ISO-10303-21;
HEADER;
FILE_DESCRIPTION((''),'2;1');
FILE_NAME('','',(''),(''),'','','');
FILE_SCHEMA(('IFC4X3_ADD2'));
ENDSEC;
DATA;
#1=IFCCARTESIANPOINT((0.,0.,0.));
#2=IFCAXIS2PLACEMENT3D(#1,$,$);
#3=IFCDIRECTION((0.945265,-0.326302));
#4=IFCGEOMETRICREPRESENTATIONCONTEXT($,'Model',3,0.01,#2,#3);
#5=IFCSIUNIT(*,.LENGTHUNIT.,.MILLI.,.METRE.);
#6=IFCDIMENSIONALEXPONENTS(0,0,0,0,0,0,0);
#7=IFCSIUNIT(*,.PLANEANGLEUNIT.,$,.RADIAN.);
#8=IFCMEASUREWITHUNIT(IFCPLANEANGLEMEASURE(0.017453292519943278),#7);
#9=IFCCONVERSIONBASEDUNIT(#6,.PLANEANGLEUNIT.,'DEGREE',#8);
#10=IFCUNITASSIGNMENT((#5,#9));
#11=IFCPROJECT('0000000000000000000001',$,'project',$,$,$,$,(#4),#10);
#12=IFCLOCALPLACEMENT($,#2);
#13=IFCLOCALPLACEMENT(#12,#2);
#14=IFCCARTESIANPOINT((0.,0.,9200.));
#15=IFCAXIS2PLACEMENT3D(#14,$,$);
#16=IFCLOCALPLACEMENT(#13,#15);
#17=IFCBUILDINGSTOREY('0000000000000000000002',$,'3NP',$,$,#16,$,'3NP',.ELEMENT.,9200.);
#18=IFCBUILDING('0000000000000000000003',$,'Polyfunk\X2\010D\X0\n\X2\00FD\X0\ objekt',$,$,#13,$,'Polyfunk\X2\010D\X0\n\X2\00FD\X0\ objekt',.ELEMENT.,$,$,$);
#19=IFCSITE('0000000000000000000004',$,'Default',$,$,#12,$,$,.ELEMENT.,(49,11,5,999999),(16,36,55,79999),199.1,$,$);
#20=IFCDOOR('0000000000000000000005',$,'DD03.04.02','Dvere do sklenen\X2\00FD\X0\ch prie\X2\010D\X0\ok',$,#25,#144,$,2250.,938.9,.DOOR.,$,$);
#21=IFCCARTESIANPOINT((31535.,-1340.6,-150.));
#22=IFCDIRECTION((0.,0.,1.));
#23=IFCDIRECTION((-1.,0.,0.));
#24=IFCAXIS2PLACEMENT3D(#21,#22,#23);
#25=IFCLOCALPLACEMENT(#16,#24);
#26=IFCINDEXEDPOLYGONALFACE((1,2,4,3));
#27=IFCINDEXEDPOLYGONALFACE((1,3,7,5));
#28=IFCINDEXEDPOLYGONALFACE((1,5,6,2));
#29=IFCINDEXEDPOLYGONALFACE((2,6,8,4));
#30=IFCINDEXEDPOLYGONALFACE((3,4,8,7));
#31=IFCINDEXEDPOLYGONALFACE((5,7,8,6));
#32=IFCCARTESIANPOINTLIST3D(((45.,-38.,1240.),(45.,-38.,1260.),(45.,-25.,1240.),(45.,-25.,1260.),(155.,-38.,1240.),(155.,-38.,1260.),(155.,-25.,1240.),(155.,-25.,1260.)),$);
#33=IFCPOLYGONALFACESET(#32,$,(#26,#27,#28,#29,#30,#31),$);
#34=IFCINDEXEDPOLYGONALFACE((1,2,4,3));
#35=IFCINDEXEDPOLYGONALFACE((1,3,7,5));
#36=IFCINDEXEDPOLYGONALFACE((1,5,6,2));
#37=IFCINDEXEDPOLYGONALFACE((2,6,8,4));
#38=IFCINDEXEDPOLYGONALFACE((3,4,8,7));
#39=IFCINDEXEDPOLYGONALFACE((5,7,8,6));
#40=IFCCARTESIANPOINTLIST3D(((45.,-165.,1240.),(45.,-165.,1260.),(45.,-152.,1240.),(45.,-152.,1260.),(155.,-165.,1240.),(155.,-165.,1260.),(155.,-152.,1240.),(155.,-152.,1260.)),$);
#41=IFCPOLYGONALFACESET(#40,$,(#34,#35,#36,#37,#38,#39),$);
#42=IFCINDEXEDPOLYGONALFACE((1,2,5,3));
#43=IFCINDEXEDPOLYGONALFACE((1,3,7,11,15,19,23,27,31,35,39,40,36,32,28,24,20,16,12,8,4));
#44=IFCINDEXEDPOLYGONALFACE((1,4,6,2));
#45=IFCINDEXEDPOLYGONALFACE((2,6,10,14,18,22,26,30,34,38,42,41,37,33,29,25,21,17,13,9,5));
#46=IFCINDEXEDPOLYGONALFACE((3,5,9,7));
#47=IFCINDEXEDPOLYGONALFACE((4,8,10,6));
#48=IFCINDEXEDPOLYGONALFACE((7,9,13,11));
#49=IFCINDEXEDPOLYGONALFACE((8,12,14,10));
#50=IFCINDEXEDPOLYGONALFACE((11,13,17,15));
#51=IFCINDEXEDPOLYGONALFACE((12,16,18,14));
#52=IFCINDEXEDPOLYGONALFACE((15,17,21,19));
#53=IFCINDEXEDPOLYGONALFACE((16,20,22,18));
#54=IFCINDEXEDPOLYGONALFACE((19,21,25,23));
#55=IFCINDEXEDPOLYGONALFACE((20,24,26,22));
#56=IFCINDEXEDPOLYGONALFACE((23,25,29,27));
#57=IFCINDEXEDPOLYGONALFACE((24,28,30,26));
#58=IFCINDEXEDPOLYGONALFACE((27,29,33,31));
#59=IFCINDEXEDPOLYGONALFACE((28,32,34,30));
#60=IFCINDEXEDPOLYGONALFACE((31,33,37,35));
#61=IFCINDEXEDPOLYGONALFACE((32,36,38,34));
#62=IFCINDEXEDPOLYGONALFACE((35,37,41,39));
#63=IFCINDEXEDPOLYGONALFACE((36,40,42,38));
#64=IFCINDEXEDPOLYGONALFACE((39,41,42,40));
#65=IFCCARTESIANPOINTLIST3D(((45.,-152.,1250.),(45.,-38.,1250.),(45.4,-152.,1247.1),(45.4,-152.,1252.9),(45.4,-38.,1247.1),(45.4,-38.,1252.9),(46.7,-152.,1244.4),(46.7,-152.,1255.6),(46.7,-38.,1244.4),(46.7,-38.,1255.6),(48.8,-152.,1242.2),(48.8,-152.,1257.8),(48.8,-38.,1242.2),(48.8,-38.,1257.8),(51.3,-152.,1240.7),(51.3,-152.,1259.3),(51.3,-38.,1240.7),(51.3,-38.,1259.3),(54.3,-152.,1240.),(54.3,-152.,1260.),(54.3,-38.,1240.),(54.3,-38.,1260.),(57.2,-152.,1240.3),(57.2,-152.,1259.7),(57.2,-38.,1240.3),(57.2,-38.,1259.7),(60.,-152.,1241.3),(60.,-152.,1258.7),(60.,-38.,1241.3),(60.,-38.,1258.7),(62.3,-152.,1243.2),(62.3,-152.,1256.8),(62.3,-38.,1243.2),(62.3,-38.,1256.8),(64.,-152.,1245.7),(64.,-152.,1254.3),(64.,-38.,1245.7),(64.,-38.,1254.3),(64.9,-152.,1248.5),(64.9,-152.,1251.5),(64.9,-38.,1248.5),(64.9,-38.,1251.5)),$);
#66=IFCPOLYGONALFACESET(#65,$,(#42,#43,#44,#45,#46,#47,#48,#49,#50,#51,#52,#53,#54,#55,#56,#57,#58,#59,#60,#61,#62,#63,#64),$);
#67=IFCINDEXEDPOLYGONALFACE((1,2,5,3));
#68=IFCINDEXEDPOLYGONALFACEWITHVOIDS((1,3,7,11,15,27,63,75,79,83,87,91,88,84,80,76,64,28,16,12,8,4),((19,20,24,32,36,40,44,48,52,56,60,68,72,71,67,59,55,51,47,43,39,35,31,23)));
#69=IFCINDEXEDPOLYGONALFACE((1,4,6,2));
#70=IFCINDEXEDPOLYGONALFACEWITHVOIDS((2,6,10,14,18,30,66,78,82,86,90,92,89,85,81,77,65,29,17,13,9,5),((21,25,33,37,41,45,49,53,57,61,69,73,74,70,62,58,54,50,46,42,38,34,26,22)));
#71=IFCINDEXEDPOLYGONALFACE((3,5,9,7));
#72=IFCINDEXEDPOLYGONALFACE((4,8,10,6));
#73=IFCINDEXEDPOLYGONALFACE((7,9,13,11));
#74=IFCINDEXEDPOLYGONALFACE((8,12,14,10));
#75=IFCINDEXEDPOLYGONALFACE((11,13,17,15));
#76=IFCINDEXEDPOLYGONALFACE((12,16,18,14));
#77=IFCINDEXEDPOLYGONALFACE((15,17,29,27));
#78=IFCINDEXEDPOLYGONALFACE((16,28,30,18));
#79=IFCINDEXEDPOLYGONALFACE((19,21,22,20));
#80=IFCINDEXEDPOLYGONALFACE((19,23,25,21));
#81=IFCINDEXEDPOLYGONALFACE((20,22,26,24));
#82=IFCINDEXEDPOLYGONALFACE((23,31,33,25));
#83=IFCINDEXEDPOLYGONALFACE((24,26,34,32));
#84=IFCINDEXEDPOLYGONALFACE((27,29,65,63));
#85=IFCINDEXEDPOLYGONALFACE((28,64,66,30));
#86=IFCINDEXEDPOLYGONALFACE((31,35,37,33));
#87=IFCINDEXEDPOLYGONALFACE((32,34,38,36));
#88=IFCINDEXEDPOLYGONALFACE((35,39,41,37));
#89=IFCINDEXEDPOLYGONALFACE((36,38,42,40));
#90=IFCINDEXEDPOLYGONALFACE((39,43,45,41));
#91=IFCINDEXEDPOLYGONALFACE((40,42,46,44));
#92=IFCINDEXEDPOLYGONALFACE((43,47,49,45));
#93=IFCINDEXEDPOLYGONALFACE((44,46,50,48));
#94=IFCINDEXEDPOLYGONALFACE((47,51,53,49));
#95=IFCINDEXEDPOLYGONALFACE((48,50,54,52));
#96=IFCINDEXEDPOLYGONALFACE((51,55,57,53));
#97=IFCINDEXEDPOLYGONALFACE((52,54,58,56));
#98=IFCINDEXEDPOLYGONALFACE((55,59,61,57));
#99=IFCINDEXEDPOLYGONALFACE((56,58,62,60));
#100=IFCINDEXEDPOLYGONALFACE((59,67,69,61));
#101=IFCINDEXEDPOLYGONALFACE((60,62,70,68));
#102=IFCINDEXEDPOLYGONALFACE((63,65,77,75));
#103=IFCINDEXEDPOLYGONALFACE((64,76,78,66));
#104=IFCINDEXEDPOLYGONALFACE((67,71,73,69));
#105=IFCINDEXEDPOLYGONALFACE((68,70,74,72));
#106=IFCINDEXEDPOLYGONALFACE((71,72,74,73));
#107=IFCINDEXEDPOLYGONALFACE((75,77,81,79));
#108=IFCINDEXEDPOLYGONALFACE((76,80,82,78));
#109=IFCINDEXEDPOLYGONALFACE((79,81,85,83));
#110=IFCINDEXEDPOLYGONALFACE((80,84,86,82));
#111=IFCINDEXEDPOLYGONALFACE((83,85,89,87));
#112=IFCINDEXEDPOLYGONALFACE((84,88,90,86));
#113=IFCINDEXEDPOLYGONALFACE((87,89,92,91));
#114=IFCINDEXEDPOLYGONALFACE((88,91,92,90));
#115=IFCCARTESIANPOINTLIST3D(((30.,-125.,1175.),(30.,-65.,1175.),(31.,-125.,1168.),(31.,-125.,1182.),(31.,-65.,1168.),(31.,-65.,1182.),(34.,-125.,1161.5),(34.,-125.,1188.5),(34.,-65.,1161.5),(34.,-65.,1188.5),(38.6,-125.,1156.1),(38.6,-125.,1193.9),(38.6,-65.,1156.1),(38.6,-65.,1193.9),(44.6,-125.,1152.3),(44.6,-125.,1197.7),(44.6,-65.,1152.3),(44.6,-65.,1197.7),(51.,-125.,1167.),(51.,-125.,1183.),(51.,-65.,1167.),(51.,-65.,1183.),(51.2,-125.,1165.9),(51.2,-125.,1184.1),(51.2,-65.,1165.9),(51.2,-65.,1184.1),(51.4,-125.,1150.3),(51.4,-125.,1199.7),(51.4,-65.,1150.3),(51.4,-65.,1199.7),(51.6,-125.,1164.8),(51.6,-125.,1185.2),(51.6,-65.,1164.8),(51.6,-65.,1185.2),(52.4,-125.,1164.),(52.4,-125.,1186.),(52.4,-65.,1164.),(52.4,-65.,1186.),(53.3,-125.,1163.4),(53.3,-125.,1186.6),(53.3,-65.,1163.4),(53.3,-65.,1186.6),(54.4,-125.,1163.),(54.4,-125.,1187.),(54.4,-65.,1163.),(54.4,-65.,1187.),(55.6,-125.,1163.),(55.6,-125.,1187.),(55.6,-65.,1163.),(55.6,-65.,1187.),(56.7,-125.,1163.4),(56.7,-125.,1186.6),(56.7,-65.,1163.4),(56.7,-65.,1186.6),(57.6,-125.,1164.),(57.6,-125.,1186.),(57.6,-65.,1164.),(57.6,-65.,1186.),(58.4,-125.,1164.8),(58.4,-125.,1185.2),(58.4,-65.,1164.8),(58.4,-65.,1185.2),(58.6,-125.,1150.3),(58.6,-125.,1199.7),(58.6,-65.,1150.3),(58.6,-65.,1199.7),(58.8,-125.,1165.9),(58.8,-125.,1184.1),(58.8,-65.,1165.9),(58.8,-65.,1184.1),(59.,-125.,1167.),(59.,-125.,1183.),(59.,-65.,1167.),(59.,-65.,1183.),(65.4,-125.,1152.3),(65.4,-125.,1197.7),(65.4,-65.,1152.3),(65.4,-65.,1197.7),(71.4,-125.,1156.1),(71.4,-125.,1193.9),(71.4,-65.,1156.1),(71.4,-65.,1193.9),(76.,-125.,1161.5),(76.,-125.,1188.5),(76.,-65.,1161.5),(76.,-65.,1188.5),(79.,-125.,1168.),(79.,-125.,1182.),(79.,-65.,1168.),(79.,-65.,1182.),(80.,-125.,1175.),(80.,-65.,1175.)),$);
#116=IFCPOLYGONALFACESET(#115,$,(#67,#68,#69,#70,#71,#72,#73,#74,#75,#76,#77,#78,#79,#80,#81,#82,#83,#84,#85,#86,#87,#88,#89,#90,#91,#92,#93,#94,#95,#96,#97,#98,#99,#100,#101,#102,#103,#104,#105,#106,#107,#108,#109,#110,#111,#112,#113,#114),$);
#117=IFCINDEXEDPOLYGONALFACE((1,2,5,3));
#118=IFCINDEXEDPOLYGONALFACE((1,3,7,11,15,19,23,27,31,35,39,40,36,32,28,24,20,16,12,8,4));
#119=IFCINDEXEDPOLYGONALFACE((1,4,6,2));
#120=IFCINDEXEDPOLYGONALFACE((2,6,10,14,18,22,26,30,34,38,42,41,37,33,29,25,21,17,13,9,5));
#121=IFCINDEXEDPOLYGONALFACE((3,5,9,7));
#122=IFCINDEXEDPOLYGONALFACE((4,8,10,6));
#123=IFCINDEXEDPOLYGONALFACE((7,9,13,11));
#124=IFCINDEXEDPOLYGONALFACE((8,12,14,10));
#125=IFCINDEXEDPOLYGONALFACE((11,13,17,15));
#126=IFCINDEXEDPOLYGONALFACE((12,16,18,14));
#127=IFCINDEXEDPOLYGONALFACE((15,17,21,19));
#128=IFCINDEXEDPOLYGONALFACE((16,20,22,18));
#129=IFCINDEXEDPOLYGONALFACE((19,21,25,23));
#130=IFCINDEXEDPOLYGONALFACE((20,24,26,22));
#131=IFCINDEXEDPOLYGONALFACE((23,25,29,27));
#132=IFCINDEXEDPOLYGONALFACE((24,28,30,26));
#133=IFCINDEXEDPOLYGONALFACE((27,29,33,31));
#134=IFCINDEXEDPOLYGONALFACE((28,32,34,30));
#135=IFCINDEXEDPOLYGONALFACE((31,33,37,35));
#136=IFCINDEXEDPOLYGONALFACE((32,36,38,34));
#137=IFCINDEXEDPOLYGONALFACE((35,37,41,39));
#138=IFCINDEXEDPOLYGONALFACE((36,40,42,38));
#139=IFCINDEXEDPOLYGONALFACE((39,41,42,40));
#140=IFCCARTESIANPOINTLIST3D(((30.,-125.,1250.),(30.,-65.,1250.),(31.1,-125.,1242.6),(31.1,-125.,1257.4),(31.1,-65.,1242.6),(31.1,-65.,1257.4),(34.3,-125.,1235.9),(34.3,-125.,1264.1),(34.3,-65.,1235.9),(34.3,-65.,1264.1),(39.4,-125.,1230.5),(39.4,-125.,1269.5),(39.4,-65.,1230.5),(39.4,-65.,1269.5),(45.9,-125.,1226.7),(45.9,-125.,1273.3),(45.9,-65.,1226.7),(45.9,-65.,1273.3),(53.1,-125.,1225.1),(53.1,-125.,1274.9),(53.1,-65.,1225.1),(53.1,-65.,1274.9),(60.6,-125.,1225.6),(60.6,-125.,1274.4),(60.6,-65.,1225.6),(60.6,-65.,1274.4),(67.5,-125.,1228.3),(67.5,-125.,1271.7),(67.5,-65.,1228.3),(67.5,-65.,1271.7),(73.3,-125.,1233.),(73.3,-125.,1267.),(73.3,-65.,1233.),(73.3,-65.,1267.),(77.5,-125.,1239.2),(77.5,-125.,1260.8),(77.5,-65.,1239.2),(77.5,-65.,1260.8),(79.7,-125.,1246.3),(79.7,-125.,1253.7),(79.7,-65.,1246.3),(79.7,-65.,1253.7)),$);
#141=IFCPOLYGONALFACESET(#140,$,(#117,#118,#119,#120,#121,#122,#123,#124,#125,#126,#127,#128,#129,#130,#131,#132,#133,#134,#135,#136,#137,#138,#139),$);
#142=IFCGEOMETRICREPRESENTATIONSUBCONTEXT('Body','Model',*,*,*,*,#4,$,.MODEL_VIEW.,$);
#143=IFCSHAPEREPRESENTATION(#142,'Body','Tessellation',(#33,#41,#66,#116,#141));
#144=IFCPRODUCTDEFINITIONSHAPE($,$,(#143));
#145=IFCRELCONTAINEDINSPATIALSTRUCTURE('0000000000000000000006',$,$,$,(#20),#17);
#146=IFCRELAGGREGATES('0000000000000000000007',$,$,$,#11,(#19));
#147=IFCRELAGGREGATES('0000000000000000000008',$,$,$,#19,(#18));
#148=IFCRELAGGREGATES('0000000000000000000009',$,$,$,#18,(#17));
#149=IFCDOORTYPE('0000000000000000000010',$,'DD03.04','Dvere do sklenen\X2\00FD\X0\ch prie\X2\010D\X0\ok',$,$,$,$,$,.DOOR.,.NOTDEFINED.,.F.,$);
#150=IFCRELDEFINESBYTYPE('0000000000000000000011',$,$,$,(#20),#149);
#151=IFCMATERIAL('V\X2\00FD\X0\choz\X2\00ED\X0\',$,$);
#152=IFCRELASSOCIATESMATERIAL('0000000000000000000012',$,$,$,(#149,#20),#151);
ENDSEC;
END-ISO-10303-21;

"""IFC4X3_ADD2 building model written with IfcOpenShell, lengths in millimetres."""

from ifc_helpers import new_model, entity, si_unit, converted_unit, direction, frame, frame_2d, origin, origin_2d_with_axis, place, context, subcontext, project, spatial, polyline, circle_curve, parameter, trimmed, segment, composite_curve, rectangle, circle, outline, extrude, source, transform, mapped, material, type_object, type_shapes, element, save


model = new_model("IFC4X3_ADD2")

# Units and contexts
model_context = context("Model", 3, precision=0.01, world=origin(), true_north=direction((0.945265, -0.326302)))
body_context = subcontext(model_context, "Body", "Model", "MODEL_VIEW")
ifc_project = project(units=[si_unit("LENGTHUNIT", "METRE", prefix="MILLI"), converted_unit("PLANEANGLEUNIT", "DEGREE", entity("IfcPlaneAngleMeasure", 0.017453292519943278), si_unit("PLANEANGLEUNIT", "RADIAN"), dimensions=[0, 0, 0, 0, 0, 0, 0])], contexts=[model_context])

# Site, building, storey
site_placement = place(None, origin())
site = spatial("IfcSite", under=ifc_project, at=site_placement, Name="Default", CompositionType="ELEMENT", RefLatitude=(49, 11, 5, 999999), RefLongitude=(16, 36, 55, 79999), RefElevation=199.1)
building_placement = place(site_placement, origin())
building = spatial("IfcBuilding", under=site, at=building_placement, Name="Polyfunkčný objekt", LongName="Polyfunkčný objekt", CompositionType="ELEMENT")
storey_placement = place(building_placement, frame((0.0, 0.0, 9200.0)))
storey = spatial("IfcBuildingStorey", under=building, at=storey_placement, Name="3NP", LongName="3NP", CompositionType="ELEMENT", Elevation=9200.0)

# Door
ifc_material_1 = material(Name="Výchozí")
door_type = type_object("IfcDoorType", Name="DD03.04", Description="Dvere do sklenených priečok", OperationType="NOTDEFINED", ParameterTakesPrecedence=False, PredefinedType="DOOR", material=ifc_material_1)
shared_shape_1 = source(origin(), body_context, "Body", "SweptSolid", [
    extrude(rectangle(XDim=110.0, YDim=13.0, at=frame_2d((0.0, 0.0), x_axis=(1.0, 0.0))), frame((100.0, -31.5, 1240.0)), (0.0, 0.0, 1.0), 20.0),
    extrude(rectangle(XDim=110.0, YDim=13.0, at=origin_2d_with_axis()), frame((100.0, -158.5, 1240.0), z_axis=(0.0, 0.0, 1.0), x_axis=(-1.0, 0.0, 0.0)), (0.0, 0.0, 1.0), 20.0),
    extrude(circle(Radius=10.0, at=origin_2d_with_axis()), frame((55.0, -152.0, 1250.0), z_axis=(0.0, 1.0, 0.0), x_axis=(-1.0, 0.0, 0.0)), (0.0, 0.0, 1.0), 114.0),
    extrude(outline(composite_curve([segment(trimmed(circle_curve(origin_2d_with_axis(), 25.0), [parameter(180.0)], [parameter(360.0)], True, "PARAMETER"), True, "CONTINUOUS"), segment(trimmed(circle_curve(origin_2d_with_axis(), 25.0), [parameter(0.0)], [parameter(180.0)], True, "PARAMETER"), True, "CONTINUOUS")], self_intersect=False), holes=[composite_curve([segment(trimmed(circle_curve(frame_2d((0.0, 8.0), x_axis=(1.0, 0.0)), 4.0), [parameter(0.0)], [parameter(180.0)], True, "PARAMETER"), False, "CONTINUOUS"), segment(polyline([(4.0, 8.0), (4.0, -8.0)]), True, "CONTINUOUS"), segment(trimmed(circle_curve(frame_2d((0.0, -8.0), x_axis=(1.0, 0.0)), 4.0), [parameter(180.0)], [parameter(0.0)], True, "PARAMETER"), False, "CONTINUOUS"), segment(polyline([(-4.0, -8.0), (-4.0, 8.0)]), True, "CONTINUOUS")], self_intersect=False)]), frame((55.0, -125.0, 1175.0), z_axis=(0.0, 1.0, 0.0), x_axis=(-1.0, 0.0, 0.0)), (0.0, 0.0, 1.0), 60.0),
    extrude(circle(Radius=25.0, at=frame_2d((0.0, 0.0), x_axis=(1.0, 0.0))), frame((55.0, -125.0, 1250.0), z_axis=(0.0, 1.0, 0.0), x_axis=(-1.0, 0.0, 0.0)), (0.0, 0.0, 1.0), 60.0),
])
type_shapes(door_type, [shared_shape_1])
door_placement = place(storey_placement, frame((31535.0, -1340.6, -150.0), z_axis=(0.0, 0.0, 1.0), x_axis=(-1.0, 0.0, 0.0)))
element("IfcDoor", 1, at=door_placement, inside=storey, type_object=door_type, material=ifc_material_1, Name="DD03.04.02", Description="Dvere do sklenených priečok", OverallHeight=2250.0, OverallWidth=938.9, PredefinedType="DOOR", context=body_context, shape_type="MappedRepresentation", body=[
    mapped(shared_shape_1, transform((0.0, 0.0, 0.0), scale=1.0)),
])

save(model, "model.ifc")
